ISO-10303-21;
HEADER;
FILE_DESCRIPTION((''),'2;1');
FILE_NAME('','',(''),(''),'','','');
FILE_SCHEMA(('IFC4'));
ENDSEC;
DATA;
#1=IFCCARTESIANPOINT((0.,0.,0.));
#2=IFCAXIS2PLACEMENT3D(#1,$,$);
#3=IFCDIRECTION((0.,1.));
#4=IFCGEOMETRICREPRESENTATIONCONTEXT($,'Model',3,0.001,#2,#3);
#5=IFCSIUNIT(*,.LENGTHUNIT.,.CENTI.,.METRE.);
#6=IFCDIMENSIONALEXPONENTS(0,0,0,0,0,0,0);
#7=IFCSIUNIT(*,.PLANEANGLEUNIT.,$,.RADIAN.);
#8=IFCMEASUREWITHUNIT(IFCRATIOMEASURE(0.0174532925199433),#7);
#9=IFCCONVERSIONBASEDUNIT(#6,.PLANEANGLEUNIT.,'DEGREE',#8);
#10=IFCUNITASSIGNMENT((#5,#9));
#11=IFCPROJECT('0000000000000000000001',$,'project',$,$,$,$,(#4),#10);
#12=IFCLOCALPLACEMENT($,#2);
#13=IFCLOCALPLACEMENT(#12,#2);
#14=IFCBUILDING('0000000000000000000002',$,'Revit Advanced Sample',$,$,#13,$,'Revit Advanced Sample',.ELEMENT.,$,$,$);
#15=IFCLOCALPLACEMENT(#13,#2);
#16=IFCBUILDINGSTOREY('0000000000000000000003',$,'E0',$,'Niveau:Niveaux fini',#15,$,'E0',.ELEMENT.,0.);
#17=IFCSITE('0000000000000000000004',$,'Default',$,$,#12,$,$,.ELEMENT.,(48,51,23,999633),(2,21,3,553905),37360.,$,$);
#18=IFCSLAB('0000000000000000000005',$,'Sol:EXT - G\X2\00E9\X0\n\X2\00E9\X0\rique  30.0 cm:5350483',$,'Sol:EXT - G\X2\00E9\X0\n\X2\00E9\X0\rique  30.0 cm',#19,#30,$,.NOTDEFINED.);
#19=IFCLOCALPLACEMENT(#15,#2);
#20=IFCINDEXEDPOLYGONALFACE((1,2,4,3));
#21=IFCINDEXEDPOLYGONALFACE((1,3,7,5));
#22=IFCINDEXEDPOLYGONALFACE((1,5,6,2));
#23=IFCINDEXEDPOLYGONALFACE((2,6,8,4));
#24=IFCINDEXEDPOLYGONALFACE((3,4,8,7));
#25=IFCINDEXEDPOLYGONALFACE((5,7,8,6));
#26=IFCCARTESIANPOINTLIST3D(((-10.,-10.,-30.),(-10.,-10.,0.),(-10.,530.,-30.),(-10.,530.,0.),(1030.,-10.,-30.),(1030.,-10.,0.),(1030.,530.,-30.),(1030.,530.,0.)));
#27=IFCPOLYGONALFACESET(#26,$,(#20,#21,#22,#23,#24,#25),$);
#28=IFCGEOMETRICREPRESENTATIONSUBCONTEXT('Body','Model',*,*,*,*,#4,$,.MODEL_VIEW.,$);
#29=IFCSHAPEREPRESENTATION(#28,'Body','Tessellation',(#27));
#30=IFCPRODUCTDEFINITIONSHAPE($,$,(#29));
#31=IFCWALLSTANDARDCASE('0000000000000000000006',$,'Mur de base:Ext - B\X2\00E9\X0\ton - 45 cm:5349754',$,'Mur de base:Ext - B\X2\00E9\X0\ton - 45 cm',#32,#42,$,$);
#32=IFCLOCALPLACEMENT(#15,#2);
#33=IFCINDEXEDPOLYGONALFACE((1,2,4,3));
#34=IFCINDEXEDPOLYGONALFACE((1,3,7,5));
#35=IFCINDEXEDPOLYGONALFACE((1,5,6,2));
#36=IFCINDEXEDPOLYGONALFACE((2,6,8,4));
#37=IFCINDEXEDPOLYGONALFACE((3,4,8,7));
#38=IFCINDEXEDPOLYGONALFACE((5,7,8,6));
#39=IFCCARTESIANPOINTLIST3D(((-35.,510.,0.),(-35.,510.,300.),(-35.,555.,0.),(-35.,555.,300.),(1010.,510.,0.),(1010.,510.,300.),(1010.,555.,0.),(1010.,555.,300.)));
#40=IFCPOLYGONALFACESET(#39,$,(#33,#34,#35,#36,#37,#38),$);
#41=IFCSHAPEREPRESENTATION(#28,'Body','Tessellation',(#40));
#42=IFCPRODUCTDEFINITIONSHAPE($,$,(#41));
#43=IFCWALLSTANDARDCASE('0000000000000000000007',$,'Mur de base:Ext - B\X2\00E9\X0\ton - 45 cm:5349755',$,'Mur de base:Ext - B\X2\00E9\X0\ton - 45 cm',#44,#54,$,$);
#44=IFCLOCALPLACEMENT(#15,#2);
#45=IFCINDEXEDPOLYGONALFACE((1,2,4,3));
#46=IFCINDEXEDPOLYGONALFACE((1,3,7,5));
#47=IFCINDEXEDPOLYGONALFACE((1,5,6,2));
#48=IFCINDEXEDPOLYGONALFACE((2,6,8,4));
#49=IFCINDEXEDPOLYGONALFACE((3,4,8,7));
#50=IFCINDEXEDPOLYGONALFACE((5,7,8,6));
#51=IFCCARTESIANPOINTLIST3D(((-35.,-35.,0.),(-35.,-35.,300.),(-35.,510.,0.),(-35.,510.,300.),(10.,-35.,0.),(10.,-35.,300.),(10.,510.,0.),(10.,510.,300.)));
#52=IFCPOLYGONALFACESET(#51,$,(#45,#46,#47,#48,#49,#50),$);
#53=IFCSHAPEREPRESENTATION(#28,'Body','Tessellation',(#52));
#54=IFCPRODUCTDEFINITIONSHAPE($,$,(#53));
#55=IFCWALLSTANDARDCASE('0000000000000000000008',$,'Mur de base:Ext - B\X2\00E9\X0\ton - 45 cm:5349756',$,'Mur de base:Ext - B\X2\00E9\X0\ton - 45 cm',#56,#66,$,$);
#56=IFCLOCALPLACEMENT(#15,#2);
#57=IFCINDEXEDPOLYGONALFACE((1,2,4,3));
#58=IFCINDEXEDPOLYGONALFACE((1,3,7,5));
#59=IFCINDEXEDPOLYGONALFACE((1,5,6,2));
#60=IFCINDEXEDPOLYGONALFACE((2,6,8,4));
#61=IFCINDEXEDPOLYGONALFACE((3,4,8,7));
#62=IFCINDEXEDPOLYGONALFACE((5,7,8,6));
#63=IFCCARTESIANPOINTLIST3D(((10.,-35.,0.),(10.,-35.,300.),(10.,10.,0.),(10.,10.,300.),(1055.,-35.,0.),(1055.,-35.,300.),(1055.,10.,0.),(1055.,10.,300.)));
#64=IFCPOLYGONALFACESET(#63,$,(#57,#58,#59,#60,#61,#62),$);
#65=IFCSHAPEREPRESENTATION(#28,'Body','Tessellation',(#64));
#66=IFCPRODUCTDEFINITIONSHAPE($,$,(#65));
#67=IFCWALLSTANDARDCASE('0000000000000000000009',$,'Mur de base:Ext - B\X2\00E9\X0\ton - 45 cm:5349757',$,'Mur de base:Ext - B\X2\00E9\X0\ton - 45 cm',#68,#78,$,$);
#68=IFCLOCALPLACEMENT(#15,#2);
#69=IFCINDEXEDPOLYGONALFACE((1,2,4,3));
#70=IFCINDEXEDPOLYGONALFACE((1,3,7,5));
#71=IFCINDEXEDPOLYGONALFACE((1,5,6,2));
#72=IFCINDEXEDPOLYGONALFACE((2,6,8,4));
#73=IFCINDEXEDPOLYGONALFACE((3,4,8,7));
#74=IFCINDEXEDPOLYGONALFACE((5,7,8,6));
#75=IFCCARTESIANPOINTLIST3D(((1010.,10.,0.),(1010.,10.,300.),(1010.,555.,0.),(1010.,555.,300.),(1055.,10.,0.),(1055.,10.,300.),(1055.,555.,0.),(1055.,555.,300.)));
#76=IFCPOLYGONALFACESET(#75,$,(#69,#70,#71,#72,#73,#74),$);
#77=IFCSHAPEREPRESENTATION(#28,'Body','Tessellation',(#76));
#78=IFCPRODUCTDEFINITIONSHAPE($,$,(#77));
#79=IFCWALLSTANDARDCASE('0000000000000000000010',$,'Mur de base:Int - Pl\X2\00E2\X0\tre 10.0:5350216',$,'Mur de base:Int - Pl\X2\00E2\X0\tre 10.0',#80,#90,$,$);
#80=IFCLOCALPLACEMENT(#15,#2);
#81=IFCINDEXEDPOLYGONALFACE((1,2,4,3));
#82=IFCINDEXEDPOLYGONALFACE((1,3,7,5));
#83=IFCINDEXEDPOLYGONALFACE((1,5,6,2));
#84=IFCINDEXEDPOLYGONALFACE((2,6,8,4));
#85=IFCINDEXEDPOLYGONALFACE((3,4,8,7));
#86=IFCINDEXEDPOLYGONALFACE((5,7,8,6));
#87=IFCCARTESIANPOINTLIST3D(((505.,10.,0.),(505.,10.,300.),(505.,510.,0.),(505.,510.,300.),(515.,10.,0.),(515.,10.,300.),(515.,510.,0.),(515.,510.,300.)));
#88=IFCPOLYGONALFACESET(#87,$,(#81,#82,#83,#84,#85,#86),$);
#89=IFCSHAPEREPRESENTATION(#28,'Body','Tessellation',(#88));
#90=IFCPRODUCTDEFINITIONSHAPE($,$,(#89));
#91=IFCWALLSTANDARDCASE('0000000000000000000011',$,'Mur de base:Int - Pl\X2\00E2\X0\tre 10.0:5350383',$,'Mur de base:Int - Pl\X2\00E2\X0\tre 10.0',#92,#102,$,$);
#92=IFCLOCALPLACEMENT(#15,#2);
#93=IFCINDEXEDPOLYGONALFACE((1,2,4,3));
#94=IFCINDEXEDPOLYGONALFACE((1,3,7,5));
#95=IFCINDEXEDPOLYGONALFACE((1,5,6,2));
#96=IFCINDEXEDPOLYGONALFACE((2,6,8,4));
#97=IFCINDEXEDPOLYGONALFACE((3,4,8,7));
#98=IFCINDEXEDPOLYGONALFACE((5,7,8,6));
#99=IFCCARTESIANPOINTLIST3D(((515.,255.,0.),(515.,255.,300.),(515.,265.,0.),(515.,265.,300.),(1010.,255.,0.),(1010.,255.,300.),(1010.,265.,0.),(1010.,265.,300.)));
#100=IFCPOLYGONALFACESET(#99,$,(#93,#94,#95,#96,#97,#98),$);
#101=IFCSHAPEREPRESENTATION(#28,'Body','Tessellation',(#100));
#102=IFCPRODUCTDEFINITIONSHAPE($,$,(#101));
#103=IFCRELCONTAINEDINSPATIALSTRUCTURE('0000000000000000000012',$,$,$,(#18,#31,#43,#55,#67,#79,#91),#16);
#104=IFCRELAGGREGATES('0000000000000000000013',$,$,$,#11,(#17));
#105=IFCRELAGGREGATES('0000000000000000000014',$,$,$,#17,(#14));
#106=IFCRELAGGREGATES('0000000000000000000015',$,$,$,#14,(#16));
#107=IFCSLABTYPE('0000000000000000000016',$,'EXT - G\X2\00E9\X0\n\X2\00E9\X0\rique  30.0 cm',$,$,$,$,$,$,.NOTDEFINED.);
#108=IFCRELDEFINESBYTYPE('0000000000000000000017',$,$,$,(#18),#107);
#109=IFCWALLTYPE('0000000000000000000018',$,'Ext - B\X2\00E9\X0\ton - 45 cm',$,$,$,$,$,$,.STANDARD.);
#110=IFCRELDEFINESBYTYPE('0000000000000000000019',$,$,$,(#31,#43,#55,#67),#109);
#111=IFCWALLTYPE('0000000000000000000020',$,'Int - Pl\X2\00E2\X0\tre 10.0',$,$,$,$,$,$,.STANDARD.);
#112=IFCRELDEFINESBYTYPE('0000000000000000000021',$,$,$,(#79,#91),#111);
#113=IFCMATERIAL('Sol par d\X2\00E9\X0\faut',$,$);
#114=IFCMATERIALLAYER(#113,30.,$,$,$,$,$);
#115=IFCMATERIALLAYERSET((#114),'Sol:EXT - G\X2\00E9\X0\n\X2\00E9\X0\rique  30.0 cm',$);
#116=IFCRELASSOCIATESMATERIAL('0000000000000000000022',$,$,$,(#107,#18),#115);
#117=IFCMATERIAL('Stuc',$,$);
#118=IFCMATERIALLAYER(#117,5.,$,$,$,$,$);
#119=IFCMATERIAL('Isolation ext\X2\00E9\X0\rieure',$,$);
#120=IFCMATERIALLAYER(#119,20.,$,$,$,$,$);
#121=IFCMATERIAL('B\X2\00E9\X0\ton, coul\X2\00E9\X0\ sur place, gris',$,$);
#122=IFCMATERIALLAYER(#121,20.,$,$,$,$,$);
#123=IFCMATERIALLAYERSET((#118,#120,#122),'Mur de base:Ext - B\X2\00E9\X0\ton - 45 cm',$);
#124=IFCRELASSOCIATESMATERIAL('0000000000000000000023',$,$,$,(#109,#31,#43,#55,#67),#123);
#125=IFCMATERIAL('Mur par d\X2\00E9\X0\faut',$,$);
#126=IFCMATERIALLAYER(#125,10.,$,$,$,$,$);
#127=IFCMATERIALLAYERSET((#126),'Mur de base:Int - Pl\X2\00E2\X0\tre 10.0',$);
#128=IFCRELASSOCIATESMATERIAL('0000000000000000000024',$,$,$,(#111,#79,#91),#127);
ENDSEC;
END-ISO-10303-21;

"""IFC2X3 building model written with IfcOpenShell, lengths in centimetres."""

from ifc_helpers import new_model, entity, si_unit, converted_unit, direction, frame, frame_2d, origin, place, context, subcontext, project, spatial, rectangle, extrude, material, layer, layer_set, layer_usage, type_object, element, save


model = new_model("IFC2X3")

# Units and contexts
model_context = context("Model", 3, precision=0.001, world=origin(), true_north=direction((0.0, 1.0)))
body_context = subcontext(model_context, "Body", "Model", "MODEL_VIEW")
ifc_project = project(units=[si_unit("LENGTHUNIT", "METRE", prefix="CENTI"), converted_unit("PLANEANGLEUNIT", "DEGREE", entity("IfcRatioMeasure", 0.0174532925199433), si_unit("PLANEANGLEUNIT", "RADIAN"), dimensions=[0, 0, 0, 0, 0, 0, 0])], contexts=[model_context])

# Site, building, storey
site_placement = place(None, origin())
site = spatial("IfcSite", under=ifc_project, at=site_placement, Name="Default", CompositionType="ELEMENT", RefLatitude=(48, 51, 23, 999633), RefLongitude=(2, 21, 3, 553905), RefElevation=37360.0)
building_placement = place(site_placement, origin())
building = spatial("IfcBuilding", under=site, at=building_placement, Name="Revit Advanced Sample", LongName="Revit Advanced Sample", CompositionType="ELEMENT")
storey_placement = place(building_placement, origin())
storey = spatial("IfcBuildingStorey", under=building, at=storey_placement, Name="E0", ObjectType="Niveau:Niveaux fini", LongName="E0", CompositionType="ELEMENT", Elevation=0.0)

# Slab
ifc_material_1 = material(Name="Sol par défaut")
ifc_layer_1 = layer(ifc_material_1, 30.0)
ifc_layer_set_1 = layer_set([ifc_layer_1], Name="Sol:EXT - Générique  30.0 cm")
ifc_layer_usage_1 = layer_usage(ifc_layer_set_1, "AXIS3", "POSITIVE", 0.0)
slab_type = type_object("IfcSlabType", Name="EXT - Générique  30.0 cm", PredefinedType="NOTDEFINED", material=ifc_layer_set_1)
slab_placement = place(storey_placement, origin())
element("IfcSlab", 1, at=slab_placement, inside=storey, type_object=slab_type, material=ifc_layer_usage_1, Name="Sol:EXT - Générique  30.0 cm:5350483", ObjectType="Sol:EXT - Générique  30.0 cm", PredefinedType="NOTDEFINED", context=body_context, shape_type="SweptSolid", body=[
    extrude(rectangle(XDim=540.0, YDim=1040.0, at=frame_2d((0.0, 0.0), x_axis=(1.0, 0.0))), frame((510.0, 260.0, 0.0), z_axis=(0.0, 0.0, -1.0), x_axis=(0.0, 1.0, 0.0)), (0.0, 0.0, 1.0), 30.0),
])

# Walls
ifc_material_2 = material(Name="Stuc")
ifc_layer_2 = layer(ifc_material_2, 5.0)
ifc_material_3 = material(Name="Isolation extérieure")
ifc_layer_3 = layer(ifc_material_3, 20.0)
ifc_material_4 = material(Name="Béton, coulé sur place, gris")
ifc_layer_4 = layer(ifc_material_4, 20.0)
ifc_layer_set_2 = layer_set([ifc_layer_2, ifc_layer_3, ifc_layer_4], Name="Mur de base:Ext - Béton - 45 cm")
ifc_layer_usage_2 = layer_usage(ifc_layer_set_2, "AXIS2", "NEGATIVE", 22.5)
wall_type_1 = type_object("IfcWallType", Name="Ext - Béton - 45 cm", PredefinedType="STANDARD", material=ifc_layer_set_2)
wall_1_placement = place(storey_placement, frame((-35.0, 532.5, 0.0)))
element("IfcWallStandardCase", 2, at=wall_1_placement, inside=storey, type_object=wall_type_1, material=ifc_layer_usage_2, Name="Mur de base:Ext - Béton - 45 cm:5349754", ObjectType="Mur de base:Ext - Béton - 45 cm", context=body_context, shape_type="SweptSolid", body=[
    extrude(rectangle(XDim=1045.0, YDim=45.0, at=frame_2d((522.5, 0.0), x_axis=(-1.0, 0.0))), origin(), (0.0, 0.0, 1.0), 300.0),
])
ifc_layer_usage_3 = layer_usage(ifc_layer_set_2, "AXIS2", "NEGATIVE", 22.5)
wall_2_placement = place(storey_placement, frame((-12.5, -35.0, 0.0), z_axis=(0.0, 0.0, 1.0), x_axis=(0.0, 1.0, 0.0)))
element("IfcWallStandardCase", 3, at=wall_2_placement, inside=storey, type_object=wall_type_1, material=ifc_layer_usage_3, Name="Mur de base:Ext - Béton - 45 cm:5349755", ObjectType="Mur de base:Ext - Béton - 45 cm", context=body_context, shape_type="SweptSolid", body=[
    extrude(rectangle(XDim=545.0, YDim=45.0, at=frame_2d((272.5, 0.0), x_axis=(-1.0, 0.0))), origin(), (0.0, 0.0, 1.0), 300.0),
])
ifc_layer_usage_4 = layer_usage(ifc_layer_set_2, "AXIS2", "NEGATIVE", 22.5)
wall_3_placement = place(storey_placement, frame((1055.0, -12.5, 0.0), z_axis=(0.0, 0.0, 1.0), x_axis=(-1.0, 0.0, 0.0)))
element("IfcWallStandardCase", 4, at=wall_3_placement, inside=storey, type_object=wall_type_1, material=ifc_layer_usage_4, Name="Mur de base:Ext - Béton - 45 cm:5349756", ObjectType="Mur de base:Ext - Béton - 45 cm", context=body_context, shape_type="SweptSolid", body=[
    extrude(rectangle(XDim=1045.0, YDim=45.0, at=frame_2d((522.5, 0.0), x_axis=(-1.0, 0.0))), origin(), (0.0, 0.0, 1.0), 300.0),
])
ifc_layer_usage_5 = layer_usage(ifc_layer_set_2, "AXIS2", "NEGATIVE", 22.5)
wall_4_placement = place(storey_placement, frame((1032.5, 555.0, 0.0), z_axis=(0.0, 0.0, 1.0), x_axis=(0.0, -1.0, 0.0)))
element("IfcWallStandardCase", 5, at=wall_4_placement, inside=storey, type_object=wall_type_1, material=ifc_layer_usage_5, Name="Mur de base:Ext - Béton - 45 cm:5349757", ObjectType="Mur de base:Ext - Béton - 45 cm", context=body_context, shape_type="SweptSolid", body=[
    extrude(rectangle(XDim=545.0, YDim=45.0, at=frame_2d((272.5, 0.0), x_axis=(-1.0, 0.0))), origin(), (0.0, 0.0, 1.0), 300.0),
])
ifc_material_5 = material(Name="Mur par défaut")
ifc_layer_5 = layer(ifc_material_5, 10.0)
ifc_layer_set_3 = layer_set([ifc_layer_5], Name="Mur de base:Int - Plâtre 10.0")
ifc_layer_usage_6 = layer_usage(ifc_layer_set_3, "AXIS2", "NEGATIVE", 5.0)
wall_type_2 = type_object("IfcWallType", Name="Int - Plâtre 10.0", PredefinedType="STANDARD", material=ifc_layer_set_3)
wall_5_placement = place(storey_placement, frame((510.0, 510.0, 0.0), z_axis=(0.0, 0.0, 1.0), x_axis=(0.0, -1.0, 0.0)))
element("IfcWallStandardCase", 6, at=wall_5_placement, inside=storey, type_object=wall_type_2, material=ifc_layer_usage_6, Name="Mur de base:Int - Plâtre 10.0:5350216", ObjectType="Mur de base:Int - Plâtre 10.0", context=body_context, shape_type="SweptSolid", body=[
    extrude(rectangle(XDim=500.0, YDim=10.0, at=frame_2d((250.0, 0.0), x_axis=(-1.0, 0.0))), origin(), (0.0, 0.0, 1.0), 300.0),
])
ifc_layer_usage_7 = layer_usage(ifc_layer_set_3, "AXIS2", "NEGATIVE", 5.0)
wall_6_placement = place(storey_placement, frame((515.0, 260.0, 0.0)))
element("IfcWallStandardCase", 7, at=wall_6_placement, inside=storey, type_object=wall_type_2, material=ifc_layer_usage_7, Name="Mur de base:Int - Plâtre 10.0:5350383", ObjectType="Mur de base:Int - Plâtre 10.0", context=body_context, shape_type="SweptSolid", body=[
    extrude(rectangle(XDim=495.0, YDim=10.0, at=frame_2d((247.5, 0.0), x_axis=(-1.0, 0.0))), origin(), (0.0, 0.0, 1.0), 300.0),
])

save(model, "model.ifc")
